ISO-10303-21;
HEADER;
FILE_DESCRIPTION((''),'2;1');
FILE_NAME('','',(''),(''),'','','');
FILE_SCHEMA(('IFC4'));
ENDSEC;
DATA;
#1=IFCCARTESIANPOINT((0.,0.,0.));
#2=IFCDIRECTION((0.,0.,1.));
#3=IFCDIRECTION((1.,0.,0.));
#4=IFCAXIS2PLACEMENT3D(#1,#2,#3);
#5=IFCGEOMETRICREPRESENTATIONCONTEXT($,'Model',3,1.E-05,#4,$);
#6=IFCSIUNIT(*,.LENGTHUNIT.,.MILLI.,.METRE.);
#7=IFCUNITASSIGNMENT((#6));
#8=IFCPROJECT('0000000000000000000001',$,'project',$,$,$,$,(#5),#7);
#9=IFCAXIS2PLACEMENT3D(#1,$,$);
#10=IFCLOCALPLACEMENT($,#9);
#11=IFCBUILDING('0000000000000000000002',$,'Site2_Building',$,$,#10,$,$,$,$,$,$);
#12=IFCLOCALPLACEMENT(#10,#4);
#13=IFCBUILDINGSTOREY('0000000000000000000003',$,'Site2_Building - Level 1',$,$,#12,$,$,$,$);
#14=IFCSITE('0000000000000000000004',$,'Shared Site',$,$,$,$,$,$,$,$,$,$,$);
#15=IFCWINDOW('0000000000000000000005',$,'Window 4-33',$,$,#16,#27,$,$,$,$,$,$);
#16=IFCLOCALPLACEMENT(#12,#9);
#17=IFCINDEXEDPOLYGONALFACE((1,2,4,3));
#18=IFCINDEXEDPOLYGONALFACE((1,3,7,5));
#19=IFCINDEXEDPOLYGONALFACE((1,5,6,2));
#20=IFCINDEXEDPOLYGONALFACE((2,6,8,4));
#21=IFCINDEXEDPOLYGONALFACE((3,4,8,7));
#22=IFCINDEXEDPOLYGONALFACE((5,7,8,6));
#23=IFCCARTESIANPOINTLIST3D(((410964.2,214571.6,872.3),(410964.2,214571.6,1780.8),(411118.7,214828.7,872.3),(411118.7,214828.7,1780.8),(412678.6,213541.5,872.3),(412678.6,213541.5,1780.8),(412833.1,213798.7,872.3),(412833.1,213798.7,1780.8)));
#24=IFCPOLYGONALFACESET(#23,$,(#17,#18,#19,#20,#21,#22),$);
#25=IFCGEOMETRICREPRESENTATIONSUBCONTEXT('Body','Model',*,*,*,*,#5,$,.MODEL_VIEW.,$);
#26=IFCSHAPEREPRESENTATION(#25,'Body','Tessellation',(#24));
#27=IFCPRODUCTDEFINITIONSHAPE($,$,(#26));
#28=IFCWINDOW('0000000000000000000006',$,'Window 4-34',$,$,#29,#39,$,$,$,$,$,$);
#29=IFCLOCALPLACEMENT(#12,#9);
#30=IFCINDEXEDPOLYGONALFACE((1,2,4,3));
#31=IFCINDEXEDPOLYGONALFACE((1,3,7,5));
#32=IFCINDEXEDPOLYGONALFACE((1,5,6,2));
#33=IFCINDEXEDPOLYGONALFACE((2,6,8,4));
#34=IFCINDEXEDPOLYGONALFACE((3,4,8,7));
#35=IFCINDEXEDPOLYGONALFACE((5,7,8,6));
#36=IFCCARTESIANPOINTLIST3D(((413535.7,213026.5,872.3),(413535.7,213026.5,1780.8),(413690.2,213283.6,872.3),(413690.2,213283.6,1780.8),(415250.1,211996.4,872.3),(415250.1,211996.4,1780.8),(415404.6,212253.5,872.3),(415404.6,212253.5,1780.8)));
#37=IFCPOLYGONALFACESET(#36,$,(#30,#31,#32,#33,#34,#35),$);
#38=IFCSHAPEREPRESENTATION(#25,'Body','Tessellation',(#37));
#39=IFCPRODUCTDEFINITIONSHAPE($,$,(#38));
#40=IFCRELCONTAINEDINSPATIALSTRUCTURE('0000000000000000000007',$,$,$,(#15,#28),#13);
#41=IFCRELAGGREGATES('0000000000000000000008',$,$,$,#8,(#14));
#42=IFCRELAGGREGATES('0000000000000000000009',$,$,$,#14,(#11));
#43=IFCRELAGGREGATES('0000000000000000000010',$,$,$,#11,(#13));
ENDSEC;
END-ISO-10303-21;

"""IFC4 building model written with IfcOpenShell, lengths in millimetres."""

from ifc_helpers import new_model, si_unit, frame, origin, origin_with_axes, place, context, subcontext, project, spatial, indexed_curve, outline, extrude, element, save


model = new_model("IFC4")

# Units and contexts
model_context = context("Model", 3, precision=1e-05, world=origin_with_axes())
body_context = subcontext(model_context, "Body", "Model", "MODEL_VIEW")
ifc_project = project(units=[si_unit("LENGTHUNIT", "METRE", prefix="MILLI")], contexts=[model_context])

# Site, building, storey
site = spatial("IfcSite", under=ifc_project, Name="Shared Site")
building_placement = place(None, origin())
building = spatial("IfcBuilding", under=site, at=building_placement, Name="Site2_Building")
storey_placement = place(building_placement, origin_with_axes())
storey = spatial("IfcBuildingStorey", under=building, at=storey_placement, Name="Site2_Building - Level 1")

# Windows
for number, where, z_axis, x_axis, name in (
    (1, (410964.2, 214571.6, 872.3), (0.0, 0.0, 1.0), (0.857167, -0.515038, 0.0), "Window 4-33"),
    (2, (413535.7, 213026.5, 872.3), (0.0, 0.0, 1.0), (0.857167, -0.515038, 0.0), "Window 4-34"),
):
    element("IfcWindow", number, at=place(storey_placement, frame(where, z_axis=z_axis, x_axis=x_axis)), inside=storey, Name=name, context=body_context, shape_type="SweptSolid", body=[
        extrude(outline(indexed_curve([(0.0, 0.0), (0.0, 300.0), (2000.0, 300.0), (2000.0, 0.0), (0.0, 0.0)], self_intersect=False)), origin_with_axes(), (0.0, 0.0, 1.0), 908.6),
    ])

save(model, "model.ifc")
